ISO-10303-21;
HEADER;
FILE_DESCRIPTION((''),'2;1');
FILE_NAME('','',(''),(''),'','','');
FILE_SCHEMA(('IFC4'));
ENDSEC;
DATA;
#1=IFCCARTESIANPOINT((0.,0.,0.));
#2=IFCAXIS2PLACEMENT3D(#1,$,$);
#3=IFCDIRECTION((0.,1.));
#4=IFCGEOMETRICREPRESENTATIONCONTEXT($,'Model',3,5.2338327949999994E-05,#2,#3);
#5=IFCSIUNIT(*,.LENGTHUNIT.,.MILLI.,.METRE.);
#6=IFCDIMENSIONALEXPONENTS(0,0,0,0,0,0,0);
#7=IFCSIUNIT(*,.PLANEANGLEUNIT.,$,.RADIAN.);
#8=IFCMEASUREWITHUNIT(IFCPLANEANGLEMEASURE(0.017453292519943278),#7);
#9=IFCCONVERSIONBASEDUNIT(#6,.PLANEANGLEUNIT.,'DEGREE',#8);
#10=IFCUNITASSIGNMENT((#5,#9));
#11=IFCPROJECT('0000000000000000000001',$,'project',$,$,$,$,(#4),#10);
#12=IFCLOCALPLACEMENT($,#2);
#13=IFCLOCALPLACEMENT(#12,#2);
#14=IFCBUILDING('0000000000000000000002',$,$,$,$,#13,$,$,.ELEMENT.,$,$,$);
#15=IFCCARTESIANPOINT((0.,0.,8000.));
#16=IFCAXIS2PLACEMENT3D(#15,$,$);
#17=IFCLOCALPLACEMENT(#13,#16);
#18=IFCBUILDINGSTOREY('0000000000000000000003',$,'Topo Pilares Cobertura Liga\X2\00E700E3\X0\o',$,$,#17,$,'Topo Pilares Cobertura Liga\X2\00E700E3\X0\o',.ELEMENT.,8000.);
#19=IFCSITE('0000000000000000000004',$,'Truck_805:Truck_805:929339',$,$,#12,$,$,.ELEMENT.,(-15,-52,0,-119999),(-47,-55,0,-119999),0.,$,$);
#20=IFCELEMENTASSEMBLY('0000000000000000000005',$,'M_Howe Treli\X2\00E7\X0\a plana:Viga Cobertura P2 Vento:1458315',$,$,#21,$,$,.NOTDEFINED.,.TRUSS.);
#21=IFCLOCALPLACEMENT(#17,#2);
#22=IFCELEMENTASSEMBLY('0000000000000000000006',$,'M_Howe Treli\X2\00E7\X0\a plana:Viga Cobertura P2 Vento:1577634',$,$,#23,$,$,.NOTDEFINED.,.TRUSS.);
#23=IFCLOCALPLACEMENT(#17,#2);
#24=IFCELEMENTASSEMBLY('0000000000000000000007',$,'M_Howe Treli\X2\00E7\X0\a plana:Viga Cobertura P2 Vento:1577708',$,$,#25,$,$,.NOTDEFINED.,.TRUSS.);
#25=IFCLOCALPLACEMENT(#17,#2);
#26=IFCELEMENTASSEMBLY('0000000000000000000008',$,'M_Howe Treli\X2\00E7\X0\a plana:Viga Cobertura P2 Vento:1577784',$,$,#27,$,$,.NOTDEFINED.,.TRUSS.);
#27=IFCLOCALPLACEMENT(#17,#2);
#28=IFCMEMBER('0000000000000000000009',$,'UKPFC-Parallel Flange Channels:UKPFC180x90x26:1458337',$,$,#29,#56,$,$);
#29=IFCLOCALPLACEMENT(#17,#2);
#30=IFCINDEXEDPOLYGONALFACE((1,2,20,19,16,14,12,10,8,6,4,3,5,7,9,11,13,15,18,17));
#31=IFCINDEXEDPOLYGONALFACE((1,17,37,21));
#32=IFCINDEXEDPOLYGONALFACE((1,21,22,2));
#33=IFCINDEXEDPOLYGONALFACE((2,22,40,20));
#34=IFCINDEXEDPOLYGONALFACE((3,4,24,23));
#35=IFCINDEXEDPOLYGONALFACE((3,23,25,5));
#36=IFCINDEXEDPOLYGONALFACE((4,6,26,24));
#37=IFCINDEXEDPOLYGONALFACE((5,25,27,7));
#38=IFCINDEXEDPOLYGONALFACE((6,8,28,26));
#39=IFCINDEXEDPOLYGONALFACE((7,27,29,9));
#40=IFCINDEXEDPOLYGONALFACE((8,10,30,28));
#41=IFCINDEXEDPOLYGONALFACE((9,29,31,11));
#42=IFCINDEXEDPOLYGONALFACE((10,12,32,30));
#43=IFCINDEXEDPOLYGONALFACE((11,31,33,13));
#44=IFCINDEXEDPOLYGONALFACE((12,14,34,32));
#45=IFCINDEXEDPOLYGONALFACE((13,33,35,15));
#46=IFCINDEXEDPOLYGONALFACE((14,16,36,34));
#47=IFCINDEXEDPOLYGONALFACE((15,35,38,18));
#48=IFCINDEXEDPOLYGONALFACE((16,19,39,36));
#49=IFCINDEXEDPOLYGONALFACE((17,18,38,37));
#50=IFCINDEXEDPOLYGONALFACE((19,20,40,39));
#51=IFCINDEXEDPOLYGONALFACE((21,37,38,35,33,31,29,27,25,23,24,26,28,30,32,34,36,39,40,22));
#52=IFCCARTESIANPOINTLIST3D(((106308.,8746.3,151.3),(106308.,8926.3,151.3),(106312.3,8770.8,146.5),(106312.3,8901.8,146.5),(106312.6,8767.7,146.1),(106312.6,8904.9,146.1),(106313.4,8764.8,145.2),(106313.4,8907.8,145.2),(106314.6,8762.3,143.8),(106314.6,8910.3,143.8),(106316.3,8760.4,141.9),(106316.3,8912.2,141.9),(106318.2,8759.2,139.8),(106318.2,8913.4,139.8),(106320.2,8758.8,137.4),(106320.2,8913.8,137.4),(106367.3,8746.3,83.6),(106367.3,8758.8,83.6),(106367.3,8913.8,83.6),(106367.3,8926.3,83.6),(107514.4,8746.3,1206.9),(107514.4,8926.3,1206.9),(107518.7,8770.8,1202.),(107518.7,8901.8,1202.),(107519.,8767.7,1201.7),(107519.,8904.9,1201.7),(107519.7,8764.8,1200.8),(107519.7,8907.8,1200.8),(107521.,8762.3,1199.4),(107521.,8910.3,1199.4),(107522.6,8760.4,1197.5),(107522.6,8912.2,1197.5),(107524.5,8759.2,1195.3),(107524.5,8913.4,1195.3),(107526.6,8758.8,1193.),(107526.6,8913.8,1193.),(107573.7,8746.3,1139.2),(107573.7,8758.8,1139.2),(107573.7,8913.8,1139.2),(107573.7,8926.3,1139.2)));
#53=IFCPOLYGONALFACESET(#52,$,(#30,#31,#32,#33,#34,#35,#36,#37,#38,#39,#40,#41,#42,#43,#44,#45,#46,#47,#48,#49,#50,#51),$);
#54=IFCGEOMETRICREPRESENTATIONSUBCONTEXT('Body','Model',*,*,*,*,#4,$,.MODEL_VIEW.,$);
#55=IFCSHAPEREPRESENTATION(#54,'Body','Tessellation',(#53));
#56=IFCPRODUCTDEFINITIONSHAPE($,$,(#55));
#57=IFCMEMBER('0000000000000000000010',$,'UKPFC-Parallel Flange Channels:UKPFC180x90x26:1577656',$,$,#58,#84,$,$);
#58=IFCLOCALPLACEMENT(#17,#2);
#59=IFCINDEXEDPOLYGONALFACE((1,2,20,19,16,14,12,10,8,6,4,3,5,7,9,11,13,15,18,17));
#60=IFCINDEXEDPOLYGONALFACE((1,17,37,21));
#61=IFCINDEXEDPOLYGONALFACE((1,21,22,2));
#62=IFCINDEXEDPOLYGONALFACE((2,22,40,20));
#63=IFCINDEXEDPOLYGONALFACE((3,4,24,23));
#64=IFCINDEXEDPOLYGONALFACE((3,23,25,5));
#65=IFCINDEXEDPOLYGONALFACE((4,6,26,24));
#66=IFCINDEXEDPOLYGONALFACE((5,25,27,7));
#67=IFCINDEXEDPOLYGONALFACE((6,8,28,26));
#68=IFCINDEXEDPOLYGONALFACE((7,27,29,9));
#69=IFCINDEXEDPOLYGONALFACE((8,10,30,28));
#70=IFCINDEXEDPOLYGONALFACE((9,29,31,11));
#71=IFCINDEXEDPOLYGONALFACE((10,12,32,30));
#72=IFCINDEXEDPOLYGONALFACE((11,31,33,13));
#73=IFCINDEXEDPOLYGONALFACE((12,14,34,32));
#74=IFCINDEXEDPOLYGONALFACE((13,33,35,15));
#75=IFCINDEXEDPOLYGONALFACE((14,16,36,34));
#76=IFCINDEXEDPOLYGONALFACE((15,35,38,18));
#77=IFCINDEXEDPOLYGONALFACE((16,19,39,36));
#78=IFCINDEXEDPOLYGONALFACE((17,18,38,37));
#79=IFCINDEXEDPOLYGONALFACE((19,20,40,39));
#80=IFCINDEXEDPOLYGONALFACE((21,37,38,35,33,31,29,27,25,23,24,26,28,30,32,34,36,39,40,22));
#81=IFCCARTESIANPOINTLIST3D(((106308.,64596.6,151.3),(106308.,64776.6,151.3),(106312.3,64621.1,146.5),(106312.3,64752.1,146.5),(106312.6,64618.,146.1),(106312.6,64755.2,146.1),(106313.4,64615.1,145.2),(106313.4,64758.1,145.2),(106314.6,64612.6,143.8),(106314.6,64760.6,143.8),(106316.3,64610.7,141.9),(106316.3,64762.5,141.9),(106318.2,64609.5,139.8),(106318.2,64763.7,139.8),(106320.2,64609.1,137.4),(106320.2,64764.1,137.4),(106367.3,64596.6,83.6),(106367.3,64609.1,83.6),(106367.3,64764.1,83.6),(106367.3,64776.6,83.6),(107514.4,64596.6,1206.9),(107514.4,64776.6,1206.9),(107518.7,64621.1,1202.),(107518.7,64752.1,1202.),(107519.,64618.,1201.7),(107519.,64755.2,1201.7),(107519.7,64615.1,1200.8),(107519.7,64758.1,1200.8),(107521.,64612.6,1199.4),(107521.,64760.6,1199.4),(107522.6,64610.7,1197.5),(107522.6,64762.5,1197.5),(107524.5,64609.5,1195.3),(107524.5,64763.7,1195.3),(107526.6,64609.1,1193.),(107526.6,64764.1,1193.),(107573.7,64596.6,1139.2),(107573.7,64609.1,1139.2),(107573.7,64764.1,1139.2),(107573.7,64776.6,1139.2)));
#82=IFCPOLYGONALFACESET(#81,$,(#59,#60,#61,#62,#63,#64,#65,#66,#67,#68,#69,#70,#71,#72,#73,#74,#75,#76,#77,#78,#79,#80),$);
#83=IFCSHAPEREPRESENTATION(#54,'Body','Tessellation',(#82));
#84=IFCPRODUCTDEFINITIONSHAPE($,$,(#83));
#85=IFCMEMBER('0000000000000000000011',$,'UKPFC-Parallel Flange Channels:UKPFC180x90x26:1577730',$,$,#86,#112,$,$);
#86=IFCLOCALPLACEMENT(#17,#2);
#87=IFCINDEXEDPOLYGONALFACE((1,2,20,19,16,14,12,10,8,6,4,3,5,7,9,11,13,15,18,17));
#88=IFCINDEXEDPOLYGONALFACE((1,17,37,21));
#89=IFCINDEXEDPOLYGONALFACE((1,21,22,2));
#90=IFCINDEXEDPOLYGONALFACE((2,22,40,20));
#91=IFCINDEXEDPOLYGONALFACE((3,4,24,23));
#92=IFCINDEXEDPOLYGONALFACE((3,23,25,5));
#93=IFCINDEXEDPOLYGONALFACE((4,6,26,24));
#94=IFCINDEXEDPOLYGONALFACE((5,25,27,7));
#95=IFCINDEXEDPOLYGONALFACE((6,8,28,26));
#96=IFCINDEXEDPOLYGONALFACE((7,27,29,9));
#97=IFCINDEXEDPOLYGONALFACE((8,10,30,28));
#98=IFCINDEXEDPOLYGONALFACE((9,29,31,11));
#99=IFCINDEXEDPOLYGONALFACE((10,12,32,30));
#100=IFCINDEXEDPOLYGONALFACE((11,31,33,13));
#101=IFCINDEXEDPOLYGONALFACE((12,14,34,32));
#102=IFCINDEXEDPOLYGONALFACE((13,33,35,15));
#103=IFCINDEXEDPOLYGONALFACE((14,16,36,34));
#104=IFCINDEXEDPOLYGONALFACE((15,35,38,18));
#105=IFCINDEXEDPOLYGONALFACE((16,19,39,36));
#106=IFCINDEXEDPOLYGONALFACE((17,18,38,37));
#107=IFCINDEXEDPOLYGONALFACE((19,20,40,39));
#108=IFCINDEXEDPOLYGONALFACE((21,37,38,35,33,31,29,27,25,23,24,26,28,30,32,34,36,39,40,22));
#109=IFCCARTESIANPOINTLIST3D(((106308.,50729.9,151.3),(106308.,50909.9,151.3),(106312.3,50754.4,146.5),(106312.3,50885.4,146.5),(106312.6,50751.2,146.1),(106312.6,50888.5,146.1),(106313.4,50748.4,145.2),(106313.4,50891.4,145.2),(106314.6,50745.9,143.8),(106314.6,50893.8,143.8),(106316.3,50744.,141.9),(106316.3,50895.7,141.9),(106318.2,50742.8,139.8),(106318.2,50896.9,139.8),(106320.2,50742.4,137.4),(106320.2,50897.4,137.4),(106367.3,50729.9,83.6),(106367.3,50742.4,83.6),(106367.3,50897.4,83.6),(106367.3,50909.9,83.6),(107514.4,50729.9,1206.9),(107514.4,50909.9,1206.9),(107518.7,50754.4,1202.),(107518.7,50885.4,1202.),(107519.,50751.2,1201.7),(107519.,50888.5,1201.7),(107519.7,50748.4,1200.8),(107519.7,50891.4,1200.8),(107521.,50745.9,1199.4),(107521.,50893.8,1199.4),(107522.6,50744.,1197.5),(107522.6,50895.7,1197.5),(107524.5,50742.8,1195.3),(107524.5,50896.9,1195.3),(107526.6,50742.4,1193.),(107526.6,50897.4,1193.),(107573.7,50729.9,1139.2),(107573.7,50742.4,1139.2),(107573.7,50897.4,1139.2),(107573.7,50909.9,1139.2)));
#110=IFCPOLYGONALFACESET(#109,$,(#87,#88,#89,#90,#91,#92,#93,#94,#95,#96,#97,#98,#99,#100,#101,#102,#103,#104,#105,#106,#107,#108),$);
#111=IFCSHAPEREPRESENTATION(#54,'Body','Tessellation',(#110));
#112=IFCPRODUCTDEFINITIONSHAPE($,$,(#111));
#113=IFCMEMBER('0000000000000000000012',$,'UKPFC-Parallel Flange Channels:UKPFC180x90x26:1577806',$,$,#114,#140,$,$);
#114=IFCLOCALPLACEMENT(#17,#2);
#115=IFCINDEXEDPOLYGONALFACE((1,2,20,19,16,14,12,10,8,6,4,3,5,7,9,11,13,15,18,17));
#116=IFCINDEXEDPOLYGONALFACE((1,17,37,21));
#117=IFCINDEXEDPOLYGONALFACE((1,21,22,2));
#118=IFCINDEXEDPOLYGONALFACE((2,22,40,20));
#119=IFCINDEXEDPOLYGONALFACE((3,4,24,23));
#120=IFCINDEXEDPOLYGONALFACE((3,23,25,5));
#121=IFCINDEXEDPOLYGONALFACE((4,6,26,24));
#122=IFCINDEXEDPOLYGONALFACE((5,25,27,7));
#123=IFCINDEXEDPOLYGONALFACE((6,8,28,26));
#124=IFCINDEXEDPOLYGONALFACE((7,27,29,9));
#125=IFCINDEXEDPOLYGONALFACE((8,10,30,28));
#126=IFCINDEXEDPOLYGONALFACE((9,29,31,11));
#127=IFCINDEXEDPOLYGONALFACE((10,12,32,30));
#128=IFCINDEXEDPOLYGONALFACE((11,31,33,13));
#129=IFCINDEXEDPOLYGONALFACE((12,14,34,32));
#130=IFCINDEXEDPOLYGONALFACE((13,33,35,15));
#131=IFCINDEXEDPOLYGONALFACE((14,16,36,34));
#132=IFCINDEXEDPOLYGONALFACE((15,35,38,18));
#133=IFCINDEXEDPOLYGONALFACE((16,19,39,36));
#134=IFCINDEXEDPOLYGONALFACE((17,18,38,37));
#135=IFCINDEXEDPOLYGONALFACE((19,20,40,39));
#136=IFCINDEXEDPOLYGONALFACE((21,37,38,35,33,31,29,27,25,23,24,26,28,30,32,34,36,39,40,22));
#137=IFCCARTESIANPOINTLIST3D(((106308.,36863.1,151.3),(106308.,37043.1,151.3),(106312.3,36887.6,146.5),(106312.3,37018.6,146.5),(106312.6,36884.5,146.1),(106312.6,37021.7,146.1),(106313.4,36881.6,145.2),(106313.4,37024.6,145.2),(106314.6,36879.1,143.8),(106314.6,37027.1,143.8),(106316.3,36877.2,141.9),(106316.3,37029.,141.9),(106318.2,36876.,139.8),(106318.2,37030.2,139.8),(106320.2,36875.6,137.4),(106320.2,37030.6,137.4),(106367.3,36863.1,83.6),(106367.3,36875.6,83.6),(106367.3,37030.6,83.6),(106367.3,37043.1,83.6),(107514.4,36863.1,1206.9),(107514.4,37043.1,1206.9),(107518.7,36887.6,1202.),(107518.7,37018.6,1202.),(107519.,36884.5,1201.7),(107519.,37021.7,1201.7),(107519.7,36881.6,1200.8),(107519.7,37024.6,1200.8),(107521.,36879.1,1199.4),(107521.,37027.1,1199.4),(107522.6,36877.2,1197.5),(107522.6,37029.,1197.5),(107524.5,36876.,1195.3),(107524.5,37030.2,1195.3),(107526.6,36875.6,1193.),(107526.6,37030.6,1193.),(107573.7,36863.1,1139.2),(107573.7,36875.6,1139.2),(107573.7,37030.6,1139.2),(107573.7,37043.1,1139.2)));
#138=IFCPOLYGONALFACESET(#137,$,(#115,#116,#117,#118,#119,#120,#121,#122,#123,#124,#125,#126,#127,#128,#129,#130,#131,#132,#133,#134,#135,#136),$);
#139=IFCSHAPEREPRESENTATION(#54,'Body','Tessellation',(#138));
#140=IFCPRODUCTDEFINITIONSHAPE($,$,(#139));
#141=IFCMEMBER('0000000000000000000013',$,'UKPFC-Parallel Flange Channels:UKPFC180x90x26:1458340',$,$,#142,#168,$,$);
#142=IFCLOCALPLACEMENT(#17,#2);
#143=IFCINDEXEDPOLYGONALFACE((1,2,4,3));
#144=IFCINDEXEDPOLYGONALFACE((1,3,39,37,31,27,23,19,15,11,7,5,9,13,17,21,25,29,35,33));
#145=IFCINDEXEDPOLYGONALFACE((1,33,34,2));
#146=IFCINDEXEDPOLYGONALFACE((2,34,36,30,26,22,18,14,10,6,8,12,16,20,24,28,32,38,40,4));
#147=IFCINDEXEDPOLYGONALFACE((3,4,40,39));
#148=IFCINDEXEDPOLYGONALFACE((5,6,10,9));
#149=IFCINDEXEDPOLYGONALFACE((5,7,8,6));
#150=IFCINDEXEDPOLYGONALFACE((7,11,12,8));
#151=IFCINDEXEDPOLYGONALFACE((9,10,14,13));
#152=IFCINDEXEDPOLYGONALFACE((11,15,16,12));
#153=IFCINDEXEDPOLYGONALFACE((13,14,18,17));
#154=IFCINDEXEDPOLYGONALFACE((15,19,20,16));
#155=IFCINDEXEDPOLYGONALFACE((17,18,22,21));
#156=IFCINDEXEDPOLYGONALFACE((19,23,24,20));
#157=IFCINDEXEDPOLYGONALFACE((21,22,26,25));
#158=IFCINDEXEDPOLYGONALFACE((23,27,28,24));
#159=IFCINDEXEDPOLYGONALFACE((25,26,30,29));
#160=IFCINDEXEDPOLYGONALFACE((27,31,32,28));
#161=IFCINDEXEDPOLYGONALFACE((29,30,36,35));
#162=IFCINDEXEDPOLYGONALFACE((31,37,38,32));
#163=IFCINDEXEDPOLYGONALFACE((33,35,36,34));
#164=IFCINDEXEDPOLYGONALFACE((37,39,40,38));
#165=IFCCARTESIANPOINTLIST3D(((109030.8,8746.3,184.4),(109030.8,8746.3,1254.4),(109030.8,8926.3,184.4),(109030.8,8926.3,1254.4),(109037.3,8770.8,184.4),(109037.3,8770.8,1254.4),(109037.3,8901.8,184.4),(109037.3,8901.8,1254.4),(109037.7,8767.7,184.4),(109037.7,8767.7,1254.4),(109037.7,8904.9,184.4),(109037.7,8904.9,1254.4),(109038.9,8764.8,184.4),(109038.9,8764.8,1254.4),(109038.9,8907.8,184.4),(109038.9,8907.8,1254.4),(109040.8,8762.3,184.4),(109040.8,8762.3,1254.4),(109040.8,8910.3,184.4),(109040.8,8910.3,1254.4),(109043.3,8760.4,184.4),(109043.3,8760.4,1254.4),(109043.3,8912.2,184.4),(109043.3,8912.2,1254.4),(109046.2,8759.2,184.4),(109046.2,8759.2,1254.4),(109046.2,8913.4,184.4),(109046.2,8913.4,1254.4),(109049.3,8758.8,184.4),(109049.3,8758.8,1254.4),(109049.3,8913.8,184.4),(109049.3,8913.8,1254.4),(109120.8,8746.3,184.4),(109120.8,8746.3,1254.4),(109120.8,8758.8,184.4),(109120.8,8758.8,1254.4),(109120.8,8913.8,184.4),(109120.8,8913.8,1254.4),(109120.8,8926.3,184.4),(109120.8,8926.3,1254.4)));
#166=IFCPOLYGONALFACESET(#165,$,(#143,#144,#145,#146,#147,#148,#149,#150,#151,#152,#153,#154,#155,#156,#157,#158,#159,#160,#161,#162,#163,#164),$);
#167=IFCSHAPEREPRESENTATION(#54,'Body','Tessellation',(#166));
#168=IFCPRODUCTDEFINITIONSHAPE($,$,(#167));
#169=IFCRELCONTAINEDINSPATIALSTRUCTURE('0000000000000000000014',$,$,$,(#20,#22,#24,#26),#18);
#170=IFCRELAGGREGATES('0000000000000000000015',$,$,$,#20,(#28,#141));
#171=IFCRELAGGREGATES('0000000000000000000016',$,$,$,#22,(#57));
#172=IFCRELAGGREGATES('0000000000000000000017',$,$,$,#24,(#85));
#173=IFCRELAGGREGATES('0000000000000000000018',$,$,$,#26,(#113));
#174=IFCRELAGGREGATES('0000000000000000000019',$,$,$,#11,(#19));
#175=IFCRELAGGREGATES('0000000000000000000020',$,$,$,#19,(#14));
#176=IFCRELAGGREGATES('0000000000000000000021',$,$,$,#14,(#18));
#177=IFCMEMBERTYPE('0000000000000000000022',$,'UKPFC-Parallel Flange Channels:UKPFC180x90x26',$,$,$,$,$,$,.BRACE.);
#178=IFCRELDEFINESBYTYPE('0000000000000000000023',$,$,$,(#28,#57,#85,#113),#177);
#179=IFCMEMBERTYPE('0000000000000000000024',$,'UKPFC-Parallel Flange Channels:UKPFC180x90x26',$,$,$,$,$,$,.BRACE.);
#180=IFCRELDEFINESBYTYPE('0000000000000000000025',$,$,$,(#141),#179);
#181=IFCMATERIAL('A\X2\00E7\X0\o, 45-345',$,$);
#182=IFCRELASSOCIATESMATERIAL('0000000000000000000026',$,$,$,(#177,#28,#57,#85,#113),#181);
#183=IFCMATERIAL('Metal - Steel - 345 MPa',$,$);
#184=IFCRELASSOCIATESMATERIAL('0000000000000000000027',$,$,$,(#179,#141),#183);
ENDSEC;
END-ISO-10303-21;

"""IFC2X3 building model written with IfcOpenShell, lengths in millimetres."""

from ifc_helpers import new_model, entity, si_unit, converted_unit, direction, frame, frame_2d, origin, place, context, subcontext, project, spatial, polyline, circle_curve, parameter, trimmed, segment, composite_curve, outline, extrude, source, transform, mapped, material, type_object, type_shapes, element, aggregate, save


model = new_model("IFC2X3")

# Units and contexts
model_context = context("Model", 3, precision=5.2338327949999994e-05, world=origin(), true_north=direction((0.0, 1.0)))
body_context = subcontext(model_context, "Body", "Model", "MODEL_VIEW")
ifc_project = project(units=[si_unit("LENGTHUNIT", "METRE", prefix="MILLI"), converted_unit("PLANEANGLEUNIT", "DEGREE", entity("IfcPlaneAngleMeasure", 0.017453292519943278), si_unit("PLANEANGLEUNIT", "RADIAN"), dimensions=[0, 0, 0, 0, 0, 0, 0])], contexts=[model_context])

# Site, building, storey
site_placement = place(None, origin())
site = spatial("IfcSite", under=ifc_project, at=site_placement, Name="Truck_805:Truck_805:929339", CompositionType="ELEMENT", RefLatitude=(-15, -52, 0, -119999), RefLongitude=(-47, -55, 0, -119999), RefElevation=0.0)
building_placement = place(site_placement, origin())
building = spatial("IfcBuilding", under=site, at=building_placement, CompositionType="ELEMENT")
storey_placement = place(building_placement, frame((0.0, 0.0, 8000.0)))
storey = spatial("IfcBuildingStorey", under=building, at=storey_placement, Name="Topo Pilares Cobertura Ligação", LongName="Topo Pilares Cobertura Ligação", CompositionType="ELEMENT", Elevation=8000.0)

# Element assemblies
ifc_material_1 = material(Name="Aço, 45-345")
assembly_1_placement = place(storey_placement, origin())
assembly_1 = element("IfcElementAssembly", 1, at=assembly_1_placement, inside=storey, Name="M_Howe Treliça plana:Viga Cobertura P2 Vento:1458315", AssemblyPlace="NOTDEFINED", PredefinedType="TRUSS")
assembly_2_placement = place(storey_placement, origin())
assembly_2 = element("IfcElementAssembly", 2, at=assembly_2_placement, inside=storey, Name="M_Howe Treliça plana:Viga Cobertura P2 Vento:1577634", AssemblyPlace="NOTDEFINED", PredefinedType="TRUSS")
assembly_3_placement = place(storey_placement, origin())
assembly_3 = element("IfcElementAssembly", 3, at=assembly_3_placement, inside=storey, Name="M_Howe Treliça plana:Viga Cobertura P2 Vento:1577708", AssemblyPlace="NOTDEFINED", PredefinedType="TRUSS")
assembly_4_placement = place(storey_placement, origin())
assembly_4 = element("IfcElementAssembly", 4, at=assembly_4_placement, inside=storey, Name="M_Howe Treliça plana:Viga Cobertura P2 Vento:1577784", AssemblyPlace="NOTDEFINED", PredefinedType="TRUSS")

# Members
member_type_1 = type_object("IfcMemberType", Name="UKPFC-Parallel Flange Channels:UKPFC180x90x26", PredefinedType="BRACE", material=ifc_material_1)
shared_shape_1 = source(origin(), body_context, "Body", "SweptSolid", [
    extrude(outline(composite_curve([segment(polyline([(-90.0, -41.0), (90.0, -41.0)]), True, "CONTINUOUS"), segment(polyline([(90.0, -41.0), (90.0, 49.0)]), True, "CONTINUOUS"), segment(polyline([(90.0, 49.0), (77.5, 49.0)]), True, "CONTINUOUS"), segment(polyline([(77.5, 49.0), (77.5, -22.5)]), True, "CONTINUOUS"), segment(trimmed(circle_curve(frame_2d((65.5, -22.5), x_axis=(1.0, 0.0)), 12.0), [parameter(270.0)], [parameter(0.0)], True, "PARAMETER"), False, "CONTINUOUS"), segment(polyline([(65.5, -34.5), (-65.5, -34.5)]), True, "CONTINUOUS"), segment(trimmed(circle_curve(frame_2d((-65.5, -22.5), x_axis=(0.0, -1.0)), 12.0), [parameter(270.0)], [parameter(0.0)], True, "PARAMETER"), False, "CONTINUOUS"), segment(polyline([(-77.5, -22.5), (-77.5, 49.0)]), True, "CONTINUOUS"), segment(polyline([(-77.5, 49.0), (-90.0, 49.0)]), True, "CONTINUOUS"), segment(polyline([(-90.0, 49.0), (-90.0, -41.0)]), True, "CONTINUOUS")], self_intersect=False)), frame((-785.0, 9.3, 0.0), z_axis=(1.0, 0.0, 0.0), x_axis=(0.0, 0.0, -1.0)), (0.0, 0.0, 1.0), 1603.0),
])
type_shapes(member_type_1, [shared_shape_1])
member_1_placement = place(assembly_1_placement, frame((106919.7, 8836.3, 644.4), z_axis=(0.0, 1.0, 0.0), x_axis=(0.752577, 0.0, 0.658505)))
member_1 = element("IfcMember", 5, at=member_1_placement, type_object=member_type_1, material=ifc_material_1, Name="UKPFC-Parallel Flange Channels:UKPFC180x90x26:1458337", context=body_context, shape_type="MappedRepresentation", body=[
    mapped(shared_shape_1, transform((0.0, 0.0, 0.0), scale=1.0)),
])
member_2_placement = place(assembly_2_placement, frame((106919.7, 64686.6, 644.4), z_axis=(0.0, 1.0, 0.0), x_axis=(0.752577, 0.0, 0.658505)))
member_2 = element("IfcMember", 6, at=member_2_placement, type_object=member_type_1, material=ifc_material_1, Name="UKPFC-Parallel Flange Channels:UKPFC180x90x26:1577656", context=body_context, shape_type="MappedRepresentation", body=[
    mapped(shared_shape_1, transform((0.0, 0.0, 0.0), scale=1.0)),
])
member_3_placement = place(assembly_3_placement, frame((106919.7, 50819.9, 644.4), z_axis=(0.0, 1.0, 0.0), x_axis=(0.752577, 0.0, 0.658505)))
member_3 = element("IfcMember", 7, at=member_3_placement, type_object=member_type_1, material=ifc_material_1, Name="UKPFC-Parallel Flange Channels:UKPFC180x90x26:1577730", context=body_context, shape_type="MappedRepresentation", body=[
    mapped(shared_shape_1, transform((0.0, 0.0, 0.0), scale=1.0)),
])
member_4_placement = place(assembly_4_placement, frame((106919.7, 36953.1, 644.4), z_axis=(0.0, 1.0, 0.0), x_axis=(0.752577, 0.0, 0.658505)))
member_4 = element("IfcMember", 8, at=member_4_placement, type_object=member_type_1, material=ifc_material_1, Name="UKPFC-Parallel Flange Channels:UKPFC180x90x26:1577806", context=body_context, shape_type="MappedRepresentation", body=[
    mapped(shared_shape_1, transform((0.0, 0.0, 0.0), scale=1.0)),
])
ifc_material_2 = material(Name="Metal - Steel - 345 MPa")
member_type_2 = type_object("IfcMemberType", Name="UKPFC-Parallel Flange Channels:UKPFC180x90x26", PredefinedType="BRACE", material=ifc_material_2)
shared_shape_2 = source(origin(), body_context, "Body", "SweptSolid", [
    extrude(outline(composite_curve([segment(polyline([(-90.0, -41.0), (90.0, -41.0)]), True, "CONTINUOUS"), segment(polyline([(90.0, -41.0), (90.0, 49.0)]), True, "CONTINUOUS"), segment(polyline([(90.0, 49.0), (77.5, 49.0)]), True, "CONTINUOUS"), segment(polyline([(77.5, 49.0), (77.5, -22.5)]), True, "CONTINUOUS"), segment(trimmed(circle_curve(frame_2d((65.5, -22.5), x_axis=(1.0, 0.0)), 12.0), [parameter(270.0)], [parameter(0.0)], True, "PARAMETER"), False, "CONTINUOUS"), segment(polyline([(65.5, -34.5), (-65.5, -34.5)]), True, "CONTINUOUS"), segment(trimmed(circle_curve(frame_2d((-65.5, -22.5), x_axis=(0.0, -1.0)), 12.0), [parameter(270.0)], [parameter(0.0)], True, "PARAMETER"), False, "CONTINUOUS"), segment(polyline([(-77.5, -22.5), (-77.5, 49.0)]), True, "CONTINUOUS"), segment(polyline([(-77.5, 49.0), (-90.0, 49.0)]), True, "CONTINUOUS"), segment(polyline([(-90.0, 49.0), (-90.0, -41.0)]), True, "CONTINUOUS")], self_intersect=False)), frame((-535.0, 9.3, 0.0), z_axis=(1.0, 0.0, 0.0), x_axis=(0.0, 0.0, -1.0)), (0.0, 0.0, 1.0), 1070.0),
])
type_shapes(member_type_2, [shared_shape_2])
member_5_placement = place(assembly_1_placement, frame((109062.5, 8836.3, 719.4), z_axis=(0.0, 1.0, 0.0), x_axis=(0.0, 0.0, 1.0)))
member_5 = element("IfcMember", 9, at=member_5_placement, type_object=member_type_2, material=ifc_material_2, Name="UKPFC-Parallel Flange Channels:UKPFC180x90x26:1458340", context=body_context, shape_type="MappedRepresentation", body=[
    mapped(shared_shape_2, transform((0.0, 0.0, 0.0), scale=1.0)),
])
aggregate(assembly_1, [member_1, member_5])
aggregate(assembly_2, [member_2])
aggregate(assembly_3, [member_3])
aggregate(assembly_4, [member_4])

save(model, "model.ifc")
